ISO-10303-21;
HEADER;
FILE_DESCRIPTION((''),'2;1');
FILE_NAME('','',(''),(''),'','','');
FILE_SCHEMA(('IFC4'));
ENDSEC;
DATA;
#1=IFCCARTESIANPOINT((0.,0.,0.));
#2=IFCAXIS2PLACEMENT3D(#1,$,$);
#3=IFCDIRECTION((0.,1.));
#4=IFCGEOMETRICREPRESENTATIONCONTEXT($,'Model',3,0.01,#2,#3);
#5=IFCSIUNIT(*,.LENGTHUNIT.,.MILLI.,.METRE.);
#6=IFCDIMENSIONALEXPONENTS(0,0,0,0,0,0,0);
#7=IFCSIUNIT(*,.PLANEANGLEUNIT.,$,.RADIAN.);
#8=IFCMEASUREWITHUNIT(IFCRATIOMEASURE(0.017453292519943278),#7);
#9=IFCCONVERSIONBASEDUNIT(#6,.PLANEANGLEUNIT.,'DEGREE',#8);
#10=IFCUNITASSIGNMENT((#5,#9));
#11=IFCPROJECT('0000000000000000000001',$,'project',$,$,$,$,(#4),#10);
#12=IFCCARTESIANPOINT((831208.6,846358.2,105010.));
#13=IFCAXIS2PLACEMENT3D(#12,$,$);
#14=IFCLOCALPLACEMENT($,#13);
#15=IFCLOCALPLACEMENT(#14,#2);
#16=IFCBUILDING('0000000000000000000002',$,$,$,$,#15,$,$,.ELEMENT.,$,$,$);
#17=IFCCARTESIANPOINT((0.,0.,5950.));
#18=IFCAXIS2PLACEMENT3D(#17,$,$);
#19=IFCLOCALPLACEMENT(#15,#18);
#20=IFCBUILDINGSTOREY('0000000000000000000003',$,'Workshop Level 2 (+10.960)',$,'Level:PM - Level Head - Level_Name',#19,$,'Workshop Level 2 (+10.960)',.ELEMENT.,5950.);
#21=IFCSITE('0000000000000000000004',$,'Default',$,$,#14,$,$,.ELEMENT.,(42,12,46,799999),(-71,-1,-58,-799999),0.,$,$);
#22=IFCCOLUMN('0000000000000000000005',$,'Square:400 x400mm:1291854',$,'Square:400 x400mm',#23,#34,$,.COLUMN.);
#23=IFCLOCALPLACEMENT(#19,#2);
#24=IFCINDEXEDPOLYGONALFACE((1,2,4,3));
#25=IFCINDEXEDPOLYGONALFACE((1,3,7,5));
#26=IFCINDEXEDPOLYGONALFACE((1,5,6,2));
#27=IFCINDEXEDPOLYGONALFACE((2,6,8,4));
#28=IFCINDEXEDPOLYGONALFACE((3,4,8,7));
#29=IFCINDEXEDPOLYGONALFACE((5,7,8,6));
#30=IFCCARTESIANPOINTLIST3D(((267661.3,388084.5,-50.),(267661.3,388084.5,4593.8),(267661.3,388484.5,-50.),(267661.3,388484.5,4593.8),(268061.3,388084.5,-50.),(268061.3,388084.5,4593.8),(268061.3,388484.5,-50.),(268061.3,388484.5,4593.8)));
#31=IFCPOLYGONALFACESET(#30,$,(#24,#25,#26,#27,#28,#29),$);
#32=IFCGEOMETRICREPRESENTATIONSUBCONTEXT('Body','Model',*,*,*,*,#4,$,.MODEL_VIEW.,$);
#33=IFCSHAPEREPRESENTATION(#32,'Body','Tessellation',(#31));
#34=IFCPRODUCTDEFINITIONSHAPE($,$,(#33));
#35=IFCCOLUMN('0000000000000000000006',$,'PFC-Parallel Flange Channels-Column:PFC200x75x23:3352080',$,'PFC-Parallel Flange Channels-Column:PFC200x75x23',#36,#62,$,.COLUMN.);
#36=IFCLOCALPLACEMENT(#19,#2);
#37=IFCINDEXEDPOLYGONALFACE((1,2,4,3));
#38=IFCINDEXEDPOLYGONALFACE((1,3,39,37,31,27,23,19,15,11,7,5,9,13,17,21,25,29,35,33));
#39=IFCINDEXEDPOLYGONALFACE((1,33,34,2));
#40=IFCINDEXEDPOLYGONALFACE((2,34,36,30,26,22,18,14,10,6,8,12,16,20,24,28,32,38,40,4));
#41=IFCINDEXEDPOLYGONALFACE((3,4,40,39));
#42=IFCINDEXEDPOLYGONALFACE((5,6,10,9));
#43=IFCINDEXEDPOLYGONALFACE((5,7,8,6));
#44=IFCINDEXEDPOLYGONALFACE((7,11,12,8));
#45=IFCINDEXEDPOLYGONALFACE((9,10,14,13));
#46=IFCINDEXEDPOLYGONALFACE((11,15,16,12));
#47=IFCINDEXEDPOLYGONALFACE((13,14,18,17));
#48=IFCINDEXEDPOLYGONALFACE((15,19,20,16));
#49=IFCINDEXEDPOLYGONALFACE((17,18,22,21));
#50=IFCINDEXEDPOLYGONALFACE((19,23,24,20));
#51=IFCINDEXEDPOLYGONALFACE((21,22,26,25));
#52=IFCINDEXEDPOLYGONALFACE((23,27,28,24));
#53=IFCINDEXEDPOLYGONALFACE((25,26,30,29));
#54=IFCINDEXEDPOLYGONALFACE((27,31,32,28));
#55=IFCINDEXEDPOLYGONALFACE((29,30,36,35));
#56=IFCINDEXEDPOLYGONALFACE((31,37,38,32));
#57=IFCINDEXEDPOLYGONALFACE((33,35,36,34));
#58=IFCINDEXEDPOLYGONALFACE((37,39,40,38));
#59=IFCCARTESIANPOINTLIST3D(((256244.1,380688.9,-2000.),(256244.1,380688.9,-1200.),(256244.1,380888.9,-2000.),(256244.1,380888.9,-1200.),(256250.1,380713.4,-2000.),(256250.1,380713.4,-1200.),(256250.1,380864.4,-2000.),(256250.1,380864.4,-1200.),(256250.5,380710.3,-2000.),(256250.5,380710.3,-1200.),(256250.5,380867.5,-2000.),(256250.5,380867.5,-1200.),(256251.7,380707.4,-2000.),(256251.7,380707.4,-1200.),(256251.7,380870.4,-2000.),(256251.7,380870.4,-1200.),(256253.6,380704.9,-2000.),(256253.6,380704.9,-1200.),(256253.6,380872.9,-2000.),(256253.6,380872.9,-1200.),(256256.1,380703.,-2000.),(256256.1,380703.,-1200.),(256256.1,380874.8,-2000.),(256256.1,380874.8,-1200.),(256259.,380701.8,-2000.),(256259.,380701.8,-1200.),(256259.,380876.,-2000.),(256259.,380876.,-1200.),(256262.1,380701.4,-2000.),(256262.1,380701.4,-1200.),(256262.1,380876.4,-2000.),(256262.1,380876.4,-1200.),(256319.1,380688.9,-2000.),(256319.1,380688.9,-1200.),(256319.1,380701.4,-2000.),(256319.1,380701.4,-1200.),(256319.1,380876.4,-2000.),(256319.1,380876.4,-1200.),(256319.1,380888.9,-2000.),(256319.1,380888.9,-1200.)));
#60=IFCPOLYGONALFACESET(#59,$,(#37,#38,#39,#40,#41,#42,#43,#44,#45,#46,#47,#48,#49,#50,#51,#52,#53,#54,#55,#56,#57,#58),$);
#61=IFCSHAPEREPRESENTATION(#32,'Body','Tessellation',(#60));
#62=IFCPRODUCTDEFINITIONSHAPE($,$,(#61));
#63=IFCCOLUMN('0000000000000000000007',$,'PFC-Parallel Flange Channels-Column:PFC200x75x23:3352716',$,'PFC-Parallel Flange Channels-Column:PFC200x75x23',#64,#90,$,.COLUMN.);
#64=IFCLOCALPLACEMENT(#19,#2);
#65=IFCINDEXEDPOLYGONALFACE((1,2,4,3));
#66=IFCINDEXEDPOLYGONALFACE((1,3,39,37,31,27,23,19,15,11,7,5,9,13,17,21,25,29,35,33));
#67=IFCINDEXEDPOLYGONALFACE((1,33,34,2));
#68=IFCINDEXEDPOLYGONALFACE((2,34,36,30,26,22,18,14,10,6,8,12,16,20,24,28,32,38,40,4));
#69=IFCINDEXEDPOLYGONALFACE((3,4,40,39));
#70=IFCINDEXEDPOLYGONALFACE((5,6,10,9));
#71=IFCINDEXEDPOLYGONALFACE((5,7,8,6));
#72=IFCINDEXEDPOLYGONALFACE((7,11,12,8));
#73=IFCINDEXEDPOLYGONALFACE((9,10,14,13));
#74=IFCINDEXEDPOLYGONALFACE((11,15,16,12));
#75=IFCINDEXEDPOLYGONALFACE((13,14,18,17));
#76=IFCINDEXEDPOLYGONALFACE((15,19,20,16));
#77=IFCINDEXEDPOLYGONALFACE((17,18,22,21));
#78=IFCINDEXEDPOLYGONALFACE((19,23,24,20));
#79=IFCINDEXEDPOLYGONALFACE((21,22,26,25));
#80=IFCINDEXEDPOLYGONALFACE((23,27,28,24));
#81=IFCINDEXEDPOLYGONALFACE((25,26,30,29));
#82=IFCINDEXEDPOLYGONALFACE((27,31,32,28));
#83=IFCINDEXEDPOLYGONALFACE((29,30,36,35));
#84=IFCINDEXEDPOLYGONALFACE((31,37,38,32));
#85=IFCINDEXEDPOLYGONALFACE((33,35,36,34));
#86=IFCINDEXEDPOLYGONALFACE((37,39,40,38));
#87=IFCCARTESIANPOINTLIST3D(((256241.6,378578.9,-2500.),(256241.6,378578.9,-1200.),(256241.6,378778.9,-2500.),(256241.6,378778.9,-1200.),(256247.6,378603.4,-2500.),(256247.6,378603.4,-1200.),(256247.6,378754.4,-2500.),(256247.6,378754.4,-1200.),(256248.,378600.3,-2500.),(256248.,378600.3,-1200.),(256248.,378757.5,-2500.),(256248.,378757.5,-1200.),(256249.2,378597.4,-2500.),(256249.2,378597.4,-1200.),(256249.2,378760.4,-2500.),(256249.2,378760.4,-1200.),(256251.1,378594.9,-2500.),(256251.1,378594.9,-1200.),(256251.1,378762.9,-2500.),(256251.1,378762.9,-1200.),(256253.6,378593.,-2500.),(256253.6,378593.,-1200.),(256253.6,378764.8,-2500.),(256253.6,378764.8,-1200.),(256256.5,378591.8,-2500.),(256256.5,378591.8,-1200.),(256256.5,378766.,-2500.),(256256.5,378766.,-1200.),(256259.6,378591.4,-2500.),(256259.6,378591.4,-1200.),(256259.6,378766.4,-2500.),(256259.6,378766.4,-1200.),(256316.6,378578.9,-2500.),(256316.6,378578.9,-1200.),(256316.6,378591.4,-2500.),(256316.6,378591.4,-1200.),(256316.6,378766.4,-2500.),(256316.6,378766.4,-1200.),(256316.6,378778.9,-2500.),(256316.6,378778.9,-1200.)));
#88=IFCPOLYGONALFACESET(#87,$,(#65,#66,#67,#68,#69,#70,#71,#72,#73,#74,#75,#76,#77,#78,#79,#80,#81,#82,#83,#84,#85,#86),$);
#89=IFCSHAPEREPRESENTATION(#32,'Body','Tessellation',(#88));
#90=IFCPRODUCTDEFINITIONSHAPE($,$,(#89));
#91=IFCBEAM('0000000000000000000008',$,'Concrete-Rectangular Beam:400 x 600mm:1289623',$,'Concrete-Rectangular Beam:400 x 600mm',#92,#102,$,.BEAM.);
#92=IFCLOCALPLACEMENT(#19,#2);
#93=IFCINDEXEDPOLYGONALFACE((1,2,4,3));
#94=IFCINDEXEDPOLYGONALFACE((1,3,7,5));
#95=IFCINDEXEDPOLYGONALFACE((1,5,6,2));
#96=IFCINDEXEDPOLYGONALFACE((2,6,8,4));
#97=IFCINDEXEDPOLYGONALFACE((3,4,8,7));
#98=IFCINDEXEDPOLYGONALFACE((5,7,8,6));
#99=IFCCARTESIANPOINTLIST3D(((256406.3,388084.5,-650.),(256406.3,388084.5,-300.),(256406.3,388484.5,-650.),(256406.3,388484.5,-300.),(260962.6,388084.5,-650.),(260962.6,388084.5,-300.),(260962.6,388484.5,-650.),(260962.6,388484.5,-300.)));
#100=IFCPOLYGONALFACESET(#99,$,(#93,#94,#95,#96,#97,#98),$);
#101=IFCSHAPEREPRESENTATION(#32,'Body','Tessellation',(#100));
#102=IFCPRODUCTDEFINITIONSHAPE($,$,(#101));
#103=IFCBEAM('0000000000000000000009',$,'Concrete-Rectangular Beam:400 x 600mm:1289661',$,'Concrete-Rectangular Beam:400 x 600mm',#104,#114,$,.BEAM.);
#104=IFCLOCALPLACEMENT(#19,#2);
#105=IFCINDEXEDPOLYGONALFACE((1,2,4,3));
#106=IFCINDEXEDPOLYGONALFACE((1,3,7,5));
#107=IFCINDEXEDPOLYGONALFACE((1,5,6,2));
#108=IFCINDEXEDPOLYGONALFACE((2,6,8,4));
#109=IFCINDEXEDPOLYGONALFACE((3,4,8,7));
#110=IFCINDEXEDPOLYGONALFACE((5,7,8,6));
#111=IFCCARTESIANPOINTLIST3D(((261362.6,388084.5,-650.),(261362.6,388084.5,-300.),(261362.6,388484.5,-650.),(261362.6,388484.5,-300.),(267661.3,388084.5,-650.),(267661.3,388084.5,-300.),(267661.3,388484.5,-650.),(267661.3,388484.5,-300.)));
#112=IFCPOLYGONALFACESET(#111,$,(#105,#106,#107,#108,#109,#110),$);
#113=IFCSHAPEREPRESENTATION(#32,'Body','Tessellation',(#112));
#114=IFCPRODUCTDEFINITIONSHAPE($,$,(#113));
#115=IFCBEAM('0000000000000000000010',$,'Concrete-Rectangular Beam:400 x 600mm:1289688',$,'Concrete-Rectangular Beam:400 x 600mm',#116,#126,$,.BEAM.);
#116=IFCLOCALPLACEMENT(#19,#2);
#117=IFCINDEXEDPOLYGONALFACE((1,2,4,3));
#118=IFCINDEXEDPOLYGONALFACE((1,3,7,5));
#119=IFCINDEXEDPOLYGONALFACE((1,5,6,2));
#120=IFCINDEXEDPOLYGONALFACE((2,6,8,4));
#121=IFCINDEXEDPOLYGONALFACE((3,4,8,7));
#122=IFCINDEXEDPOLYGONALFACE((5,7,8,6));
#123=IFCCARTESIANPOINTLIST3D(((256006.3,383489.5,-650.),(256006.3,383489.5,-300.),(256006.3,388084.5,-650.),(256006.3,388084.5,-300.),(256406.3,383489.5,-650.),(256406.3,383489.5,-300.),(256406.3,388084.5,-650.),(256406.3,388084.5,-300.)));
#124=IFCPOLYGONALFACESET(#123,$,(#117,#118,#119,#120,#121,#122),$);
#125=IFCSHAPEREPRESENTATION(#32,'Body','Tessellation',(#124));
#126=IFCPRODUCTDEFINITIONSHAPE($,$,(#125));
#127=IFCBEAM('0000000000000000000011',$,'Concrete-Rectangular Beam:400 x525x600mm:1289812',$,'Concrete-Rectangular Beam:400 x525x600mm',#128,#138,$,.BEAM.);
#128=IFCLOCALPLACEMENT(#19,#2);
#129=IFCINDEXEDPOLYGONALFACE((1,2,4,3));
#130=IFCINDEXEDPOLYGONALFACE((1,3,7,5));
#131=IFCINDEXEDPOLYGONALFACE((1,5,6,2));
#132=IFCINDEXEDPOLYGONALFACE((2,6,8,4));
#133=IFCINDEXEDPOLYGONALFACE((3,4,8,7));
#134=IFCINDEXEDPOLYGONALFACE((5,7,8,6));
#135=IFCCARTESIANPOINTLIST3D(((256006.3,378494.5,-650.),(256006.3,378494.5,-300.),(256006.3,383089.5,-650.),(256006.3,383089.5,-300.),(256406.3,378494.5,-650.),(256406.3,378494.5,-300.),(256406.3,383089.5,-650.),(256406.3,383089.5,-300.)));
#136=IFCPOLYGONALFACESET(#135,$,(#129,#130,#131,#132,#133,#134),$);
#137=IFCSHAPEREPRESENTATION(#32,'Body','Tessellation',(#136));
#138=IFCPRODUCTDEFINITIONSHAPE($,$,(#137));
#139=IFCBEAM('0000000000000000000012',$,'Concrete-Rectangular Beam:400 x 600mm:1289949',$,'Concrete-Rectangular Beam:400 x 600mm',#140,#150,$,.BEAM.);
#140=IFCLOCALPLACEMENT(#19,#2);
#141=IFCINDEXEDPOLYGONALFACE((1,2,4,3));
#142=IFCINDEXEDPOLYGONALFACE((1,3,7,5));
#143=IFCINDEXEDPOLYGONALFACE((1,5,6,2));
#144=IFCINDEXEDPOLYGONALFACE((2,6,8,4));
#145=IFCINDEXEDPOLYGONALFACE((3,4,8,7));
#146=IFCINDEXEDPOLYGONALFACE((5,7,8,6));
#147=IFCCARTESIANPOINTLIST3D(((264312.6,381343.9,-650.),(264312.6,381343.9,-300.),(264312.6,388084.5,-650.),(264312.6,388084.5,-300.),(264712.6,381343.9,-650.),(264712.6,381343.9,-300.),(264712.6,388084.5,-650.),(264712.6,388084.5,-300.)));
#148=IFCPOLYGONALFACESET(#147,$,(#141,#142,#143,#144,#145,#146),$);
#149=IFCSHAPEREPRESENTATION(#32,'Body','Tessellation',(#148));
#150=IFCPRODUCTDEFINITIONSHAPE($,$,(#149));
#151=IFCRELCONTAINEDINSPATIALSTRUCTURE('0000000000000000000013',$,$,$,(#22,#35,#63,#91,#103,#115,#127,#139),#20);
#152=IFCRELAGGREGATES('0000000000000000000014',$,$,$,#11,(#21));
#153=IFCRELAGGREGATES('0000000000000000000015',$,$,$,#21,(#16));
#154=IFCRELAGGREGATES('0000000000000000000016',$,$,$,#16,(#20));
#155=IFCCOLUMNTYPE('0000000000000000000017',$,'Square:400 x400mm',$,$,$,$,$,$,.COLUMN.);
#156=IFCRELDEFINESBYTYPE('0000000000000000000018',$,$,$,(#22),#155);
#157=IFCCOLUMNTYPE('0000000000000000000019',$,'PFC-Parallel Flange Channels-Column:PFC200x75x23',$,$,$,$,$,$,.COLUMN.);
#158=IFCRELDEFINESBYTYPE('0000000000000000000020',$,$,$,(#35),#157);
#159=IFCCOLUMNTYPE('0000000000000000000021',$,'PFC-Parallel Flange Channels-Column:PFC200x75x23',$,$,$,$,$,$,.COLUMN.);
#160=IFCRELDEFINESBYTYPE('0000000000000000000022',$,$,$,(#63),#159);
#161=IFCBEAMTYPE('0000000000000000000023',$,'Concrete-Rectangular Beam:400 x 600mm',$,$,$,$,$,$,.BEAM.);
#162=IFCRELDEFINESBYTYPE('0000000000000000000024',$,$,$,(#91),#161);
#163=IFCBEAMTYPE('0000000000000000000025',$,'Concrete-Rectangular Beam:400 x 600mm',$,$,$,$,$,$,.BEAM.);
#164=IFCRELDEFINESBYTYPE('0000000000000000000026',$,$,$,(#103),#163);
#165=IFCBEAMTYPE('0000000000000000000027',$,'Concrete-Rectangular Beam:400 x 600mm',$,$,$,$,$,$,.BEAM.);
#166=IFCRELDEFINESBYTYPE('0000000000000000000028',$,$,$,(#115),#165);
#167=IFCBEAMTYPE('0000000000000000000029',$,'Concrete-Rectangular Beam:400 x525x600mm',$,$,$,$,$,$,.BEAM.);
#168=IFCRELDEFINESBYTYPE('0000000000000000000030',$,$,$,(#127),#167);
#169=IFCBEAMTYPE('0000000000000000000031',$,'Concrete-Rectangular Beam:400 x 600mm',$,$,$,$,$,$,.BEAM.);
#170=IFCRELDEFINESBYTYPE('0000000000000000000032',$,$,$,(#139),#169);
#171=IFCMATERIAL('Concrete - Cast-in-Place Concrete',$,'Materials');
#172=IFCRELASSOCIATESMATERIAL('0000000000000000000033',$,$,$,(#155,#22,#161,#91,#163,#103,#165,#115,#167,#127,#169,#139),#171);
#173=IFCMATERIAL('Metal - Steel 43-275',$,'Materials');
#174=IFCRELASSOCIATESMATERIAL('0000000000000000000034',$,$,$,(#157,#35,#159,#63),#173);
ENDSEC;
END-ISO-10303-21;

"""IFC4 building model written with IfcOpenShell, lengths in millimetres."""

from ifc_helpers import new_model, entity, si_unit, converted_unit, direction, frame, origin, place, context, subcontext, project, spatial, line, arc, indexed_curve, outline, extrude, source, transform, mapped, material, type_object, type_shapes, element, save


model = new_model("IFC4")

# Units and contexts
model_context = context("Model", 3, precision=0.01, world=origin(), true_north=direction((0.0, 1.0)))
body_context = subcontext(model_context, "Body", "Model", "MODEL_VIEW")
ifc_project = project(units=[si_unit("LENGTHUNIT", "METRE", prefix="MILLI"), converted_unit("PLANEANGLEUNIT", "DEGREE", entity("IfcRatioMeasure", 0.017453292519943278), si_unit("PLANEANGLEUNIT", "RADIAN"), dimensions=[0, 0, 0, 0, 0, 0, 0])], contexts=[model_context])

# Site, building, storey
site_placement = place(None, frame((831208.6, 846358.2, 105010.0)))
site = spatial("IfcSite", under=ifc_project, at=site_placement, Name="Default", CompositionType="ELEMENT", RefLatitude=(42, 12, 46, 799999), RefLongitude=(-71, -1, -58, -799999), RefElevation=0.0)
building_placement = place(site_placement, origin())
building = spatial("IfcBuilding", under=site, at=building_placement, CompositionType="ELEMENT")
storey_placement = place(building_placement, frame((0.0, 0.0, 5950.0)))
storey = spatial("IfcBuildingStorey", under=building, at=storey_placement, Name="Workshop Level 2 (+10.960)", ObjectType="Level:PM - Level Head - Level_Name", LongName="Workshop Level 2 (+10.960)", CompositionType="ELEMENT", Elevation=5950.0)

# Columns
ifc_material_1 = material(Name="Concrete - Cast-in-Place Concrete", Category="Materials")
column_type_1 = type_object("IfcColumnType", Name="Square:400 x400mm", PredefinedType="COLUMN", material=ifc_material_1)
shared_shape_1 = source(origin(), body_context, "Body", "SweptSolid", [
    extrude(outline(indexed_curve([(-200.0, -200.0), (200.0, -200.0), (200.0, 200.0), (-200.0, 200.0), (-200.0, -200.0)], self_intersect=False)), frame((267861.3, 388284.5, 5900.0), z_axis=(0.0, 0.0, 1.0), x_axis=(0.0, 1.0, 0.0)), (0.0, 0.0, 1.0), 4643.8),
])
type_shapes(column_type_1, [shared_shape_1])
column_1_placement = place(storey_placement, frame((0.0, 0.0, -5950.0)))
element("IfcColumn", 1, at=column_1_placement, inside=storey, type_object=column_type_1, material=ifc_material_1, Name="Square:400 x400mm:1291854", ObjectType="Square:400 x400mm", PredefinedType="COLUMN", context=body_context, shape_type="MappedRepresentation", body=[
    mapped(shared_shape_1, transform((0.0, 0.0, 0.0), scale=1.0)),
])
ifc_material_2 = material(Name="Metal - Steel 43-275", Category="Materials")
column_type_2 = type_object("IfcColumnType", Name="PFC-Parallel Flange Channels-Column:PFC200x75x23", PredefinedType="COLUMN", material=ifc_material_2)
shared_shape_2 = source(origin(), body_context, "Body", "SweptSolid", [
    extrude(outline(indexed_curve([(-100.0, -34.8), (100.0, -34.8), (100.0, 40.2), (87.5, 40.2), (87.5, -16.8), (84.0, -25.3), (75.5, -28.8), (-75.5, -28.8), (-84.0, -25.3), (-87.5, -16.8), (-87.5, 40.2), (-100.0, 40.2)], segments=[line(1, 2, 3, 4, 5), arc(5, 6, 7), line(7, 8), arc(8, 9, 10), line(10, 11, 12, 1)], self_intersect=False)), frame((256278.9, 380788.9, 3950.0), z_axis=(0.0, 0.0, 1.0), x_axis=(0.0, -1.0, 0.0)), (0.0, 0.0, 1.0), 800.0),
])
type_shapes(column_type_2, [shared_shape_2])
column_2_placement = place(storey_placement, frame((0.0, 0.0, -5950.0)))
element("IfcColumn", 2, at=column_2_placement, inside=storey, type_object=column_type_2, material=ifc_material_2, Name="PFC-Parallel Flange Channels-Column:PFC200x75x23:3352080", ObjectType="PFC-Parallel Flange Channels-Column:PFC200x75x23", PredefinedType="COLUMN", context=body_context, shape_type="MappedRepresentation", body=[
    mapped(shared_shape_2, transform((0.0, 0.0, 0.0), scale=1.0)),
])
column_type_3 = type_object("IfcColumnType", Name="PFC-Parallel Flange Channels-Column:PFC200x75x23", PredefinedType="COLUMN", material=ifc_material_2)
shared_shape_3 = source(origin(), body_context, "Body", "SweptSolid", [
    extrude(outline(indexed_curve([(-100.0, -34.8), (100.0, -34.8), (100.0, 40.2), (87.5, 40.2), (87.5, -16.8), (84.0, -25.3), (75.5, -28.8), (-75.5, -28.8), (-84.0, -25.3), (-87.5, -16.8), (-87.5, 40.2), (-100.0, 40.2)], segments=[line(1, 2, 3, 4, 5), arc(5, 6, 7), line(7, 8), arc(8, 9, 10), line(10, 11, 12, 1)], self_intersect=False)), frame((256276.4, 378678.9, 3450.0), z_axis=(0.0, 0.0, 1.0), x_axis=(0.0, -1.0, 0.0)), (0.0, 0.0, 1.0), 1300.0),
])
type_shapes(column_type_3, [shared_shape_3])
column_3_placement = place(storey_placement, frame((0.0, 0.0, -5950.0)))
element("IfcColumn", 3, at=column_3_placement, inside=storey, type_object=column_type_3, material=ifc_material_2, Name="PFC-Parallel Flange Channels-Column:PFC200x75x23:3352716", ObjectType="PFC-Parallel Flange Channels-Column:PFC200x75x23", PredefinedType="COLUMN", context=body_context, shape_type="MappedRepresentation", body=[
    mapped(shared_shape_3, transform((0.0, 0.0, 0.0), scale=1.0)),
])

# Beams
beam_type_1 = type_object("IfcBeamType", Name="Concrete-Rectangular Beam:400 x 600mm", PredefinedType="BEAM", material=ifc_material_1)
shared_shape_4 = source(origin(), body_context, "Body", "SweptSolid", [
    extrude(outline(indexed_curve([(-175.0, -200.0), (175.0, -200.0), (175.0, 200.0), (-175.0, 200.0), (-175.0, -200.0)], self_intersect=False)), frame((256406.3, 388284.5, 5475.0), z_axis=(1.0, 0.0, 0.0), x_axis=(0.0, 0.0, -1.0)), (0.0, 0.0, 1.0), 4556.3),
])
type_shapes(beam_type_1, [shared_shape_4])
beam_1_placement = place(storey_placement, frame((0.0, 0.0, -5950.0)))
element("IfcBeam", 4, at=beam_1_placement, inside=storey, type_object=beam_type_1, material=ifc_material_1, Name="Concrete-Rectangular Beam:400 x 600mm:1289623", ObjectType="Concrete-Rectangular Beam:400 x 600mm", PredefinedType="BEAM", context=body_context, shape_type="MappedRepresentation", body=[
    mapped(shared_shape_4, transform((0.0, 0.0, 0.0), scale=1.0)),
])
beam_type_2 = type_object("IfcBeamType", Name="Concrete-Rectangular Beam:400 x 600mm", PredefinedType="BEAM", material=ifc_material_1)
shared_shape_5 = source(origin(), body_context, "Body", "SweptSolid", [
    extrude(outline(indexed_curve([(-175.0, -200.0), (175.0, -200.0), (175.0, 200.0), (-175.0, 200.0), (-175.0, -200.0)], self_intersect=False)), frame((261362.6, 388284.5, 5475.0), z_axis=(1.0, 0.0, 0.0), x_axis=(0.0, 0.0, -1.0)), (0.0, 0.0, 1.0), 6298.7),
])
type_shapes(beam_type_2, [shared_shape_5])
beam_2_placement = place(storey_placement, frame((0.0, 0.0, -5950.0)))
element("IfcBeam", 5, at=beam_2_placement, inside=storey, type_object=beam_type_2, material=ifc_material_1, Name="Concrete-Rectangular Beam:400 x 600mm:1289661", ObjectType="Concrete-Rectangular Beam:400 x 600mm", PredefinedType="BEAM", context=body_context, shape_type="MappedRepresentation", body=[
    mapped(shared_shape_5, transform((0.0, 0.0, 0.0), scale=1.0)),
])
beam_type_3 = type_object("IfcBeamType", Name="Concrete-Rectangular Beam:400 x 600mm", PredefinedType="BEAM", material=ifc_material_1)
shared_shape_6 = source(origin(), body_context, "Body", "SweptSolid", [
    extrude(outline(indexed_curve([(-200.0, -175.0), (200.0, -175.0), (200.0, 175.0), (-200.0, 175.0), (-200.0, -175.0)], self_intersect=False)), frame((256206.3, 383489.5, 5475.0), z_axis=(0.0, 1.0, 0.0), x_axis=(-1.0, 0.0, 0.0)), (0.0, 0.0, 1.0), 4595.0),
])
type_shapes(beam_type_3, [shared_shape_6])
beam_3_placement = place(storey_placement, frame((0.0, 0.0, -5950.0)))
element("IfcBeam", 6, at=beam_3_placement, inside=storey, type_object=beam_type_3, material=ifc_material_1, Name="Concrete-Rectangular Beam:400 x 600mm:1289688", ObjectType="Concrete-Rectangular Beam:400 x 600mm", PredefinedType="BEAM", context=body_context, shape_type="MappedRepresentation", body=[
    mapped(shared_shape_6, transform((0.0, 0.0, 0.0), scale=1.0)),
])
beam_type_4 = type_object("IfcBeamType", Name="Concrete-Rectangular Beam:400 x525x600mm", PredefinedType="BEAM", material=ifc_material_1)
shared_shape_7 = source(origin(), body_context, "Body", "SweptSolid", [
    extrude(outline(indexed_curve([(-200.0, -175.0), (200.0, -175.0), (200.0, 175.0), (-200.0, 175.0), (-200.0, -175.0)], self_intersect=False)), frame((256206.3, 378494.5, 5475.0), z_axis=(0.0, 1.0, 0.0), x_axis=(-1.0, 0.0, 0.0)), (0.0, 0.0, 1.0), 4595.0),
])
type_shapes(beam_type_4, [shared_shape_7])
beam_4_placement = place(storey_placement, frame((0.0, 0.0, -5950.0)))
element("IfcBeam", 7, at=beam_4_placement, inside=storey, type_object=beam_type_4, material=ifc_material_1, Name="Concrete-Rectangular Beam:400 x525x600mm:1289812", ObjectType="Concrete-Rectangular Beam:400 x525x600mm", PredefinedType="BEAM", context=body_context, shape_type="MappedRepresentation", body=[
    mapped(shared_shape_7, transform((0.0, 0.0, 0.0), scale=1.0)),
])
beam_type_5 = type_object("IfcBeamType", Name="Concrete-Rectangular Beam:400 x 600mm", PredefinedType="BEAM", material=ifc_material_1)
shared_shape_8 = source(origin(), body_context, "Body", "SweptSolid", [
    extrude(outline(indexed_curve([(-200.0, -175.0), (200.0, -175.0), (200.0, 175.0), (-200.0, 175.0), (-200.0, -175.0)], self_intersect=False)), frame((264512.6, 388084.5, 5475.0), z_axis=(0.0, -1.0, 0.0), x_axis=(-1.0, 0.0, 0.0)), (0.0, 0.0, 1.0), 6740.6),
])
type_shapes(beam_type_5, [shared_shape_8])
beam_5_placement = place(storey_placement, frame((0.0, 0.0, -5950.0)))
element("IfcBeam", 8, at=beam_5_placement, inside=storey, type_object=beam_type_5, material=ifc_material_1, Name="Concrete-Rectangular Beam:400 x 600mm:1289949", ObjectType="Concrete-Rectangular Beam:400 x 600mm", PredefinedType="BEAM", context=body_context, shape_type="MappedRepresentation", body=[
    mapped(shared_shape_8, transform((0.0, 0.0, 0.0), scale=1.0)),
])

save(model, "model.ifc")
